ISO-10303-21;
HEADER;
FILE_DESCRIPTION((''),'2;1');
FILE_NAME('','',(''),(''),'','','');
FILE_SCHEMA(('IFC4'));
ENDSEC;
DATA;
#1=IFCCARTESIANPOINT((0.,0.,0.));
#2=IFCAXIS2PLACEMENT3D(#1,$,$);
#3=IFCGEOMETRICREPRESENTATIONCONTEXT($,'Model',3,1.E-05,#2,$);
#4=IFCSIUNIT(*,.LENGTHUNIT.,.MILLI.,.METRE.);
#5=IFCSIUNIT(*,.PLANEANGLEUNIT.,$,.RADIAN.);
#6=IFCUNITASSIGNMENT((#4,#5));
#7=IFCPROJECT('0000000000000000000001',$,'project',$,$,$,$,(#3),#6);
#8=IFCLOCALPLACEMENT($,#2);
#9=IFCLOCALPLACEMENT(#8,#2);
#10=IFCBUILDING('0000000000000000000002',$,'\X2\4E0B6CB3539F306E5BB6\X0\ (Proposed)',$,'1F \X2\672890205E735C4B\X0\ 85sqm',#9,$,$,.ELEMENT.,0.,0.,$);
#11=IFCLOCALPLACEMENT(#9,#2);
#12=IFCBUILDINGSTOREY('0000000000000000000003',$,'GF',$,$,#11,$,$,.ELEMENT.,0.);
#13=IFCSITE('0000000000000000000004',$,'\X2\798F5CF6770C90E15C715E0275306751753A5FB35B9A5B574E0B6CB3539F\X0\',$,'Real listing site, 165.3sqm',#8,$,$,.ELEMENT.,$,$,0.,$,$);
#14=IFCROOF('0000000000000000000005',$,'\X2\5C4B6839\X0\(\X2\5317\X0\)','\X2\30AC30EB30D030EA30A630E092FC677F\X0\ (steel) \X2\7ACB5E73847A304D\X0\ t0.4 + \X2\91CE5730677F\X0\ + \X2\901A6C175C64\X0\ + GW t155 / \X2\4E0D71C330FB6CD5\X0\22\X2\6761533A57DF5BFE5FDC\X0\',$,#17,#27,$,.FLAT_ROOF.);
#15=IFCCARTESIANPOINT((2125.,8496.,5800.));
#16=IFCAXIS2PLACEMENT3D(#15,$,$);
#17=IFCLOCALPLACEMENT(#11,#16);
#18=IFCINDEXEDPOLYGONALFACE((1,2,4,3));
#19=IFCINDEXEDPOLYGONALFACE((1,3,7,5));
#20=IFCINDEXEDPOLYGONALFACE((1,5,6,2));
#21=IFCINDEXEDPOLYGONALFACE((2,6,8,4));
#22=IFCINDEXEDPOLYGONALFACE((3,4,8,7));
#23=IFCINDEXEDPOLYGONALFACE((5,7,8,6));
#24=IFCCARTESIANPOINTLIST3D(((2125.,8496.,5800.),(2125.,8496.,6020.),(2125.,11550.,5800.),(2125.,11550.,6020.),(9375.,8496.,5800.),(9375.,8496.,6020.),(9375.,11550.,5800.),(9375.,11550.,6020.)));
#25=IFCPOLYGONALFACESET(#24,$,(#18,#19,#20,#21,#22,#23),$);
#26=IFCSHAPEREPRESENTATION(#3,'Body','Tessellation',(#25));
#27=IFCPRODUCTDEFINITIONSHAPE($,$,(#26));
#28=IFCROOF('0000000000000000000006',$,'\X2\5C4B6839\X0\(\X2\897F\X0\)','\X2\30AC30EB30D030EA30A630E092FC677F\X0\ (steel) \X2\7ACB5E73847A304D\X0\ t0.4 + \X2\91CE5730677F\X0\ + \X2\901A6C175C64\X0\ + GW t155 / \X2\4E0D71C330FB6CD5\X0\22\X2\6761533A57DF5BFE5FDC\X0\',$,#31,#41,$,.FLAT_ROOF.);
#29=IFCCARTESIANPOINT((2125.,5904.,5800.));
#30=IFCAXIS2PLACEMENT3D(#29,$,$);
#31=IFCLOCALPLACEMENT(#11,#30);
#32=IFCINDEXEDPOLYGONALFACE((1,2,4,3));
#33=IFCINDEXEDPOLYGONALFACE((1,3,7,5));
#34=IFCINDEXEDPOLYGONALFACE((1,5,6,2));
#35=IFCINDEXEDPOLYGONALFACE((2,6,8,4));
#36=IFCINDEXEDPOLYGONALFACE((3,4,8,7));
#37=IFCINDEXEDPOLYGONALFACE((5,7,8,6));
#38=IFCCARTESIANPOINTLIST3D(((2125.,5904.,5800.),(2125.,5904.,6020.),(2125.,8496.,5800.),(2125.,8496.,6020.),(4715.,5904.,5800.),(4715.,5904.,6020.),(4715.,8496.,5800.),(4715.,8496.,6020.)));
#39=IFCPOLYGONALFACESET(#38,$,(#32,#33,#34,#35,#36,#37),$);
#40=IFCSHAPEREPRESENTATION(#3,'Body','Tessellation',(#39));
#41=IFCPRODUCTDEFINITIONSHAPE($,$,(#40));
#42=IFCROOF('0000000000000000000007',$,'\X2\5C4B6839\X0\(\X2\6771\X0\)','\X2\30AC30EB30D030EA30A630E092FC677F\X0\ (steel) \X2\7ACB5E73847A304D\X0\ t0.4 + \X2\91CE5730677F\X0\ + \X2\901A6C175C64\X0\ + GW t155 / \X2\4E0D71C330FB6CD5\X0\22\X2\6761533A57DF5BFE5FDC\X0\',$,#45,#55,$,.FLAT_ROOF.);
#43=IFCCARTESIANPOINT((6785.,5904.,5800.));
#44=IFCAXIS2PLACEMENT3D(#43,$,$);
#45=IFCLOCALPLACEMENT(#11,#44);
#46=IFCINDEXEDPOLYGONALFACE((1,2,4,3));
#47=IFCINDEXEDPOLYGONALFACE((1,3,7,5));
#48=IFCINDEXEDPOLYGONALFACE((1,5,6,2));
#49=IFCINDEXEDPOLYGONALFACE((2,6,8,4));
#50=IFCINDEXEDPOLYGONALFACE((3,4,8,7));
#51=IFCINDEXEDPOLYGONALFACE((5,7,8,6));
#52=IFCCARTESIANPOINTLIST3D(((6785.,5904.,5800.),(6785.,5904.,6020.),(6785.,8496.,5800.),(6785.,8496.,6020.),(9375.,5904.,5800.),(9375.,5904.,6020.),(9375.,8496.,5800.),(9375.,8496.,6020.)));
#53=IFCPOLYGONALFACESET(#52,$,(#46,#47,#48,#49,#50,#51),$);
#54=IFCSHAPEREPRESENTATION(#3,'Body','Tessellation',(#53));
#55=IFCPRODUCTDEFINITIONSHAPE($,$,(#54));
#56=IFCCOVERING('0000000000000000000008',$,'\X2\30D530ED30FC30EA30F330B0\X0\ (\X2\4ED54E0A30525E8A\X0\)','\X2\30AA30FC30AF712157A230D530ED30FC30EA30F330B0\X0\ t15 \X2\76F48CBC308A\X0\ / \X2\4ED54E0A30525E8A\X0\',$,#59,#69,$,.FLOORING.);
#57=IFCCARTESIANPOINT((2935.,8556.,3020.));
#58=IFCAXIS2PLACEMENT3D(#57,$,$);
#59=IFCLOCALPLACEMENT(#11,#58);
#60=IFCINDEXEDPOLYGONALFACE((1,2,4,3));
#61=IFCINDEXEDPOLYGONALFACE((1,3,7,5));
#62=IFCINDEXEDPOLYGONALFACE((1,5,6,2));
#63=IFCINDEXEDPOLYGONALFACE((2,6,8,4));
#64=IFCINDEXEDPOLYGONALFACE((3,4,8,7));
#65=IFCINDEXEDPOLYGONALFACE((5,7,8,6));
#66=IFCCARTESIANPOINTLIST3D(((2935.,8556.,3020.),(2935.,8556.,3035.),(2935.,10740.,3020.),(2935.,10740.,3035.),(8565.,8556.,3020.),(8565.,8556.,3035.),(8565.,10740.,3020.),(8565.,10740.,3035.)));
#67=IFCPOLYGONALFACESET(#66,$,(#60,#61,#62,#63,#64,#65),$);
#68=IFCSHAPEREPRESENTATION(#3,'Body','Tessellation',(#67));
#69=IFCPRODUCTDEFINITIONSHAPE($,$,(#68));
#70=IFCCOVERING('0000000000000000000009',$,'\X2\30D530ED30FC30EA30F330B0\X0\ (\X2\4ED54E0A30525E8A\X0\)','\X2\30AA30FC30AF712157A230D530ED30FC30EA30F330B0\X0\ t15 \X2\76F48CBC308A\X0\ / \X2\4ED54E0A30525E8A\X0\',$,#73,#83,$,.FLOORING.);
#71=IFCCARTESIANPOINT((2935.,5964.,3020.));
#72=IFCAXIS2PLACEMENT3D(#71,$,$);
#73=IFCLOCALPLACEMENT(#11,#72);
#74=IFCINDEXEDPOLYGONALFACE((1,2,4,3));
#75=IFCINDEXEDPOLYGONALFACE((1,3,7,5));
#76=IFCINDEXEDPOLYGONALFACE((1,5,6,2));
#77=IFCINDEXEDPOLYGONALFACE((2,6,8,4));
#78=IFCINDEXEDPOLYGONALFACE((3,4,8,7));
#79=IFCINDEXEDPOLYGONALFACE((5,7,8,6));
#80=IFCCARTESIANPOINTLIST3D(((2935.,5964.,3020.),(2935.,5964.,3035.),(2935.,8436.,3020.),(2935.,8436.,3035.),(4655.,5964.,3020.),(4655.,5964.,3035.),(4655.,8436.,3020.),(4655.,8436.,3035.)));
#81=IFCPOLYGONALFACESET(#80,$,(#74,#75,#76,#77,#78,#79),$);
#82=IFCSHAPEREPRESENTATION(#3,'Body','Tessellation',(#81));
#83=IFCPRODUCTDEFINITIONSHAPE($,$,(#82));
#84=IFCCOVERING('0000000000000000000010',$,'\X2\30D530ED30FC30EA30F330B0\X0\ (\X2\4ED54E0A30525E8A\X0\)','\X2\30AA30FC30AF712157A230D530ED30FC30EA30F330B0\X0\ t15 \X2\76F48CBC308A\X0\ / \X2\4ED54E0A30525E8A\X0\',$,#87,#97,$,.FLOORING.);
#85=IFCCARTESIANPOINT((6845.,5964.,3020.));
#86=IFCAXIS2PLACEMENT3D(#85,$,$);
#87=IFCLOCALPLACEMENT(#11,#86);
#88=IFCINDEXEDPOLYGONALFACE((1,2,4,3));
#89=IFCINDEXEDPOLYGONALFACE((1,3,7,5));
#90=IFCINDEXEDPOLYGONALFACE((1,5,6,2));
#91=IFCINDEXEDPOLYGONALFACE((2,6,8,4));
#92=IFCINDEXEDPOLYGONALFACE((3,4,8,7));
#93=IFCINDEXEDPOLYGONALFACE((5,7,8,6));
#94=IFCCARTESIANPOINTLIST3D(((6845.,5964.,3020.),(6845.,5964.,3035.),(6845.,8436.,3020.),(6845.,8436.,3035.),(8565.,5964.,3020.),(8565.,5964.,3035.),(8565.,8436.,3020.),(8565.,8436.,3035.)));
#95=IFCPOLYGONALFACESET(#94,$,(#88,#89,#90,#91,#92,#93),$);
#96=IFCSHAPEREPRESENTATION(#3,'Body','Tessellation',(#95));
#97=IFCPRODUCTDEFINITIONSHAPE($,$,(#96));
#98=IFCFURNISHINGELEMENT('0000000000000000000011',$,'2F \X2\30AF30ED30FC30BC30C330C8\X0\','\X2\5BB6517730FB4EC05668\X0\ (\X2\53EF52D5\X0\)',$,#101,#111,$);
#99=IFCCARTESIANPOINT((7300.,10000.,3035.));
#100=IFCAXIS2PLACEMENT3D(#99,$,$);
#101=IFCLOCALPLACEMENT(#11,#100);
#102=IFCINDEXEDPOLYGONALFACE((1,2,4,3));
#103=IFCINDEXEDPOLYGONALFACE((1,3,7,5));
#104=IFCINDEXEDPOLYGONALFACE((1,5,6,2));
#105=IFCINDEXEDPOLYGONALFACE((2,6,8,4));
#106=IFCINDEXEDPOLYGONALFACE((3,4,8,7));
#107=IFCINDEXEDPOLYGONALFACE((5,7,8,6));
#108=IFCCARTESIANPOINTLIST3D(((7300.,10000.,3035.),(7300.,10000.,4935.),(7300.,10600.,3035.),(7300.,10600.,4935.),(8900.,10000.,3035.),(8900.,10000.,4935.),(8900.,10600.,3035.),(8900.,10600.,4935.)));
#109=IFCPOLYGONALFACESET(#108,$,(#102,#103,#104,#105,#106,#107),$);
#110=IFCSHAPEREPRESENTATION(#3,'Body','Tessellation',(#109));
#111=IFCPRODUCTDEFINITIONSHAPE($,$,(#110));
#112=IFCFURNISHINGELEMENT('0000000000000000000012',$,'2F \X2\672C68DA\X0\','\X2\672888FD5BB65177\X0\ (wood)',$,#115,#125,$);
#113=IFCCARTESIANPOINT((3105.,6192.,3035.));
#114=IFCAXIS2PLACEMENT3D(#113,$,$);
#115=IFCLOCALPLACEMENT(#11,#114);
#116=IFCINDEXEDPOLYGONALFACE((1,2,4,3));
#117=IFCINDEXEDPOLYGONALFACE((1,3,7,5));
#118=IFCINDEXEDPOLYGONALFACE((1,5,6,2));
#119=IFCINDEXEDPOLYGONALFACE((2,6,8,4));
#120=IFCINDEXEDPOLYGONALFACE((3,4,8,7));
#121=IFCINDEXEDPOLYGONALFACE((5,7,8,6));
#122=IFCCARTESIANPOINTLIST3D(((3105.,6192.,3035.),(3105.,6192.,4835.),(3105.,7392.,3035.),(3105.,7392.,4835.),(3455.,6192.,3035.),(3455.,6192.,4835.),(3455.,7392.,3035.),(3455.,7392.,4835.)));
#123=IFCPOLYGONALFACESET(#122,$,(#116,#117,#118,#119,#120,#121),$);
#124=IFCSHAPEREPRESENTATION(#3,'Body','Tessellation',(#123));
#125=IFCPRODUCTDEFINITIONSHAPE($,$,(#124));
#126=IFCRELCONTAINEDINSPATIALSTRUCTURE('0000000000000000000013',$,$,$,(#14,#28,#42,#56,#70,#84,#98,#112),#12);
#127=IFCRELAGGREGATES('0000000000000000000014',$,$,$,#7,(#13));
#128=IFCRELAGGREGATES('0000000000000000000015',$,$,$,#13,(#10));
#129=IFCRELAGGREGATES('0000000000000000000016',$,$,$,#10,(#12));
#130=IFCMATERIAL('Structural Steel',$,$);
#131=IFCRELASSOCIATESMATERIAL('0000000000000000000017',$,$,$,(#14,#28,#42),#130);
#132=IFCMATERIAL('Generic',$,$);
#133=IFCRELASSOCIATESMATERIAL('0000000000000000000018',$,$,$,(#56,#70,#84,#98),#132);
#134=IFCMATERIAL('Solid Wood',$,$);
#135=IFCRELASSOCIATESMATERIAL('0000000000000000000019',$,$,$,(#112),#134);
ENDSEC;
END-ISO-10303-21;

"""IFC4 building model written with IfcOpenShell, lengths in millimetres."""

from ifc_helpers import new_model, si_unit, frame, frame_2d, origin, place, context, project, spatial, rectangle, extrude, material, element, save


model = new_model("IFC4")

# Units and contexts
model_context = context("Model", 3, precision=1e-05, world=origin())
ifc_project = project(units=[si_unit("LENGTHUNIT", "METRE", prefix="MILLI"), si_unit("PLANEANGLEUNIT", "RADIAN")], contexts=[model_context])

# Site, building, storey
site_placement = place(None, origin())
site = spatial("IfcSite", under=ifc_project, at=site_placement, Name="福島県郡山市田村町徳定字下河原", ObjectType="Real listing site, 165.3sqm", CompositionType="ELEMENT", RefElevation=0.0)
building_placement = place(site_placement, origin())
building = spatial("IfcBuilding", under=site, at=building_placement, Name="下河原の家 (Proposed)", ObjectType="1F 木造平屋 85sqm", CompositionType="ELEMENT", ElevationOfRefHeight=0.0, ElevationOfTerrain=0.0)
storey_placement = place(building_placement, origin())
storey = spatial("IfcBuildingStorey", under=building, at=storey_placement, Name="GF", CompositionType="ELEMENT", Elevation=0.0)

# Shared definitions
ifc_material_1 = material(Name="Solid Wood")

# Shared definitions
ifc_material_2 = material(Name="Generic")

# Roofs
ifc_material_3 = material(Name="Structural Steel")
for number, where, name in (
    (1, (2125.0, 8496.0, 5800.0), "屋根(北)"),
):
    element("IfcRoof", number, at=place(storey_placement, frame(where)), inside=storey, material=ifc_material_3, Name=name, Description="ガルバリウム鋼板 (steel) 立平葺き t0.4 + 野地板 + 通気層 + GW t155 / 不燃・法22条区域対応", PredefinedType="FLAT_ROOF", context=model_context, shape_type="SweptSolid", body=[
        extrude(rectangle(XDim=7250.0, YDim=3054.0, at=frame_2d((3625.0, 1527.0))), frame((2125.0, 8496.0, 5800.0)), (0.0, 0.0, 1.0), 220.0),
    ])
roof_1_placement = place(storey_placement, frame((2125.0, 5904.0, 5800.0)))
element("IfcRoof", 2, at=roof_1_placement, inside=storey, material=ifc_material_3, Name="屋根(西)", Description="ガルバリウム鋼板 (steel) 立平葺き t0.4 + 野地板 + 通気層 + GW t155 / 不燃・法22条区域対応", PredefinedType="FLAT_ROOF", context=model_context, shape_type="SweptSolid", body=[
    extrude(rectangle(XDim=2590.0, YDim=2592.0, at=frame_2d((1295.0, 1296.0))), frame((2125.0, 5904.0, 5800.0)), (0.0, 0.0, 1.0), 220.0),
])
roof_2_placement = place(storey_placement, frame((6785.0, 5904.0, 5800.0)))
element("IfcRoof", 3, at=roof_2_placement, inside=storey, material=ifc_material_3, Name="屋根(東)", Description="ガルバリウム鋼板 (steel) 立平葺き t0.4 + 野地板 + 通気層 + GW t155 / 不燃・法22条区域対応", PredefinedType="FLAT_ROOF", context=model_context, shape_type="SweptSolid", body=[
    extrude(rectangle(XDim=2590.0, YDim=2592.0, at=frame_2d((1295.0, 1296.0))), frame((6785.0, 5904.0, 5800.0)), (0.0, 0.0, 1.0), 220.0),
])

# Coverings
covering_1_placement = place(storey_placement, frame((2935.0, 8556.0, 3020.0)))
element("IfcCovering", 4, at=covering_1_placement, inside=storey, material=ifc_material_2, Name="フローリング (仕上げ床)", Description="オーク無垢フローリング t15 直貼り / 仕上げ床", PredefinedType="FLOORING", context=model_context, shape_type="SweptSolid", body=[
    extrude(rectangle(XDim=5630.0, YDim=2184.0, at=frame_2d((2815.0, 1092.0))), frame((2935.0, 8556.0, 3020.0)), (0.0, 0.0, 1.0), 15.0),
])
covering_2_placement = place(storey_placement, frame((2935.0, 5964.0, 3020.0)))
element("IfcCovering", 5, at=covering_2_placement, inside=storey, material=ifc_material_2, Name="フローリング (仕上げ床)", Description="オーク無垢フローリング t15 直貼り / 仕上げ床", PredefinedType="FLOORING", context=model_context, shape_type="SweptSolid", body=[
    extrude(rectangle(XDim=1720.0, YDim=2472.0, at=frame_2d((860.0, 1236.0))), frame((2935.0, 5964.0, 3020.0)), (0.0, 0.0, 1.0), 15.0),
])
covering_3_placement = place(storey_placement, frame((6845.0, 5964.0, 3020.0)))
element("IfcCovering", 6, at=covering_3_placement, inside=storey, material=ifc_material_2, Name="フローリング (仕上げ床)", Description="オーク無垢フローリング t15 直貼り / 仕上げ床", PredefinedType="FLOORING", context=model_context, shape_type="SweptSolid", body=[
    extrude(rectangle(XDim=1720.0, YDim=2472.0, at=frame_2d((860.0, 1236.0))), frame((6845.0, 5964.0, 3020.0)), (0.0, 0.0, 1.0), 15.0),
])

# Furnishing elements
furnishing_1_placement = place(storey_placement, frame((7300.0, 10000.0, 3035.0)))
element("IfcFurnishingElement", 7, at=furnishing_1_placement, inside=storey, material=ifc_material_2, Name="2F クローゼット", Description="家具・什器 (可動)", context=model_context, shape_type="SweptSolid", body=[
    extrude(rectangle(XDim=1600.0, YDim=600.0, at=frame_2d((800.0, 300.0))), frame((7300.0, 10000.0, 3035.0)), (0.0, 0.0, 1.0), 1900.0),
])
furnishing_2_placement = place(storey_placement, frame((3105.0, 6192.0, 3035.0)))
element("IfcFurnishingElement", 8, at=furnishing_2_placement, inside=storey, material=ifc_material_1, Name="2F 本棚", Description="木製家具 (wood)", context=model_context, shape_type="SweptSolid", body=[
    extrude(rectangle(XDim=350.0, YDim=1200.0, at=frame_2d((175.0, 600.0))), frame((3105.0, 6192.0, 3035.0)), (0.0, 0.0, 1.0), 1800.0),
])

save(model, "model.ifc")
